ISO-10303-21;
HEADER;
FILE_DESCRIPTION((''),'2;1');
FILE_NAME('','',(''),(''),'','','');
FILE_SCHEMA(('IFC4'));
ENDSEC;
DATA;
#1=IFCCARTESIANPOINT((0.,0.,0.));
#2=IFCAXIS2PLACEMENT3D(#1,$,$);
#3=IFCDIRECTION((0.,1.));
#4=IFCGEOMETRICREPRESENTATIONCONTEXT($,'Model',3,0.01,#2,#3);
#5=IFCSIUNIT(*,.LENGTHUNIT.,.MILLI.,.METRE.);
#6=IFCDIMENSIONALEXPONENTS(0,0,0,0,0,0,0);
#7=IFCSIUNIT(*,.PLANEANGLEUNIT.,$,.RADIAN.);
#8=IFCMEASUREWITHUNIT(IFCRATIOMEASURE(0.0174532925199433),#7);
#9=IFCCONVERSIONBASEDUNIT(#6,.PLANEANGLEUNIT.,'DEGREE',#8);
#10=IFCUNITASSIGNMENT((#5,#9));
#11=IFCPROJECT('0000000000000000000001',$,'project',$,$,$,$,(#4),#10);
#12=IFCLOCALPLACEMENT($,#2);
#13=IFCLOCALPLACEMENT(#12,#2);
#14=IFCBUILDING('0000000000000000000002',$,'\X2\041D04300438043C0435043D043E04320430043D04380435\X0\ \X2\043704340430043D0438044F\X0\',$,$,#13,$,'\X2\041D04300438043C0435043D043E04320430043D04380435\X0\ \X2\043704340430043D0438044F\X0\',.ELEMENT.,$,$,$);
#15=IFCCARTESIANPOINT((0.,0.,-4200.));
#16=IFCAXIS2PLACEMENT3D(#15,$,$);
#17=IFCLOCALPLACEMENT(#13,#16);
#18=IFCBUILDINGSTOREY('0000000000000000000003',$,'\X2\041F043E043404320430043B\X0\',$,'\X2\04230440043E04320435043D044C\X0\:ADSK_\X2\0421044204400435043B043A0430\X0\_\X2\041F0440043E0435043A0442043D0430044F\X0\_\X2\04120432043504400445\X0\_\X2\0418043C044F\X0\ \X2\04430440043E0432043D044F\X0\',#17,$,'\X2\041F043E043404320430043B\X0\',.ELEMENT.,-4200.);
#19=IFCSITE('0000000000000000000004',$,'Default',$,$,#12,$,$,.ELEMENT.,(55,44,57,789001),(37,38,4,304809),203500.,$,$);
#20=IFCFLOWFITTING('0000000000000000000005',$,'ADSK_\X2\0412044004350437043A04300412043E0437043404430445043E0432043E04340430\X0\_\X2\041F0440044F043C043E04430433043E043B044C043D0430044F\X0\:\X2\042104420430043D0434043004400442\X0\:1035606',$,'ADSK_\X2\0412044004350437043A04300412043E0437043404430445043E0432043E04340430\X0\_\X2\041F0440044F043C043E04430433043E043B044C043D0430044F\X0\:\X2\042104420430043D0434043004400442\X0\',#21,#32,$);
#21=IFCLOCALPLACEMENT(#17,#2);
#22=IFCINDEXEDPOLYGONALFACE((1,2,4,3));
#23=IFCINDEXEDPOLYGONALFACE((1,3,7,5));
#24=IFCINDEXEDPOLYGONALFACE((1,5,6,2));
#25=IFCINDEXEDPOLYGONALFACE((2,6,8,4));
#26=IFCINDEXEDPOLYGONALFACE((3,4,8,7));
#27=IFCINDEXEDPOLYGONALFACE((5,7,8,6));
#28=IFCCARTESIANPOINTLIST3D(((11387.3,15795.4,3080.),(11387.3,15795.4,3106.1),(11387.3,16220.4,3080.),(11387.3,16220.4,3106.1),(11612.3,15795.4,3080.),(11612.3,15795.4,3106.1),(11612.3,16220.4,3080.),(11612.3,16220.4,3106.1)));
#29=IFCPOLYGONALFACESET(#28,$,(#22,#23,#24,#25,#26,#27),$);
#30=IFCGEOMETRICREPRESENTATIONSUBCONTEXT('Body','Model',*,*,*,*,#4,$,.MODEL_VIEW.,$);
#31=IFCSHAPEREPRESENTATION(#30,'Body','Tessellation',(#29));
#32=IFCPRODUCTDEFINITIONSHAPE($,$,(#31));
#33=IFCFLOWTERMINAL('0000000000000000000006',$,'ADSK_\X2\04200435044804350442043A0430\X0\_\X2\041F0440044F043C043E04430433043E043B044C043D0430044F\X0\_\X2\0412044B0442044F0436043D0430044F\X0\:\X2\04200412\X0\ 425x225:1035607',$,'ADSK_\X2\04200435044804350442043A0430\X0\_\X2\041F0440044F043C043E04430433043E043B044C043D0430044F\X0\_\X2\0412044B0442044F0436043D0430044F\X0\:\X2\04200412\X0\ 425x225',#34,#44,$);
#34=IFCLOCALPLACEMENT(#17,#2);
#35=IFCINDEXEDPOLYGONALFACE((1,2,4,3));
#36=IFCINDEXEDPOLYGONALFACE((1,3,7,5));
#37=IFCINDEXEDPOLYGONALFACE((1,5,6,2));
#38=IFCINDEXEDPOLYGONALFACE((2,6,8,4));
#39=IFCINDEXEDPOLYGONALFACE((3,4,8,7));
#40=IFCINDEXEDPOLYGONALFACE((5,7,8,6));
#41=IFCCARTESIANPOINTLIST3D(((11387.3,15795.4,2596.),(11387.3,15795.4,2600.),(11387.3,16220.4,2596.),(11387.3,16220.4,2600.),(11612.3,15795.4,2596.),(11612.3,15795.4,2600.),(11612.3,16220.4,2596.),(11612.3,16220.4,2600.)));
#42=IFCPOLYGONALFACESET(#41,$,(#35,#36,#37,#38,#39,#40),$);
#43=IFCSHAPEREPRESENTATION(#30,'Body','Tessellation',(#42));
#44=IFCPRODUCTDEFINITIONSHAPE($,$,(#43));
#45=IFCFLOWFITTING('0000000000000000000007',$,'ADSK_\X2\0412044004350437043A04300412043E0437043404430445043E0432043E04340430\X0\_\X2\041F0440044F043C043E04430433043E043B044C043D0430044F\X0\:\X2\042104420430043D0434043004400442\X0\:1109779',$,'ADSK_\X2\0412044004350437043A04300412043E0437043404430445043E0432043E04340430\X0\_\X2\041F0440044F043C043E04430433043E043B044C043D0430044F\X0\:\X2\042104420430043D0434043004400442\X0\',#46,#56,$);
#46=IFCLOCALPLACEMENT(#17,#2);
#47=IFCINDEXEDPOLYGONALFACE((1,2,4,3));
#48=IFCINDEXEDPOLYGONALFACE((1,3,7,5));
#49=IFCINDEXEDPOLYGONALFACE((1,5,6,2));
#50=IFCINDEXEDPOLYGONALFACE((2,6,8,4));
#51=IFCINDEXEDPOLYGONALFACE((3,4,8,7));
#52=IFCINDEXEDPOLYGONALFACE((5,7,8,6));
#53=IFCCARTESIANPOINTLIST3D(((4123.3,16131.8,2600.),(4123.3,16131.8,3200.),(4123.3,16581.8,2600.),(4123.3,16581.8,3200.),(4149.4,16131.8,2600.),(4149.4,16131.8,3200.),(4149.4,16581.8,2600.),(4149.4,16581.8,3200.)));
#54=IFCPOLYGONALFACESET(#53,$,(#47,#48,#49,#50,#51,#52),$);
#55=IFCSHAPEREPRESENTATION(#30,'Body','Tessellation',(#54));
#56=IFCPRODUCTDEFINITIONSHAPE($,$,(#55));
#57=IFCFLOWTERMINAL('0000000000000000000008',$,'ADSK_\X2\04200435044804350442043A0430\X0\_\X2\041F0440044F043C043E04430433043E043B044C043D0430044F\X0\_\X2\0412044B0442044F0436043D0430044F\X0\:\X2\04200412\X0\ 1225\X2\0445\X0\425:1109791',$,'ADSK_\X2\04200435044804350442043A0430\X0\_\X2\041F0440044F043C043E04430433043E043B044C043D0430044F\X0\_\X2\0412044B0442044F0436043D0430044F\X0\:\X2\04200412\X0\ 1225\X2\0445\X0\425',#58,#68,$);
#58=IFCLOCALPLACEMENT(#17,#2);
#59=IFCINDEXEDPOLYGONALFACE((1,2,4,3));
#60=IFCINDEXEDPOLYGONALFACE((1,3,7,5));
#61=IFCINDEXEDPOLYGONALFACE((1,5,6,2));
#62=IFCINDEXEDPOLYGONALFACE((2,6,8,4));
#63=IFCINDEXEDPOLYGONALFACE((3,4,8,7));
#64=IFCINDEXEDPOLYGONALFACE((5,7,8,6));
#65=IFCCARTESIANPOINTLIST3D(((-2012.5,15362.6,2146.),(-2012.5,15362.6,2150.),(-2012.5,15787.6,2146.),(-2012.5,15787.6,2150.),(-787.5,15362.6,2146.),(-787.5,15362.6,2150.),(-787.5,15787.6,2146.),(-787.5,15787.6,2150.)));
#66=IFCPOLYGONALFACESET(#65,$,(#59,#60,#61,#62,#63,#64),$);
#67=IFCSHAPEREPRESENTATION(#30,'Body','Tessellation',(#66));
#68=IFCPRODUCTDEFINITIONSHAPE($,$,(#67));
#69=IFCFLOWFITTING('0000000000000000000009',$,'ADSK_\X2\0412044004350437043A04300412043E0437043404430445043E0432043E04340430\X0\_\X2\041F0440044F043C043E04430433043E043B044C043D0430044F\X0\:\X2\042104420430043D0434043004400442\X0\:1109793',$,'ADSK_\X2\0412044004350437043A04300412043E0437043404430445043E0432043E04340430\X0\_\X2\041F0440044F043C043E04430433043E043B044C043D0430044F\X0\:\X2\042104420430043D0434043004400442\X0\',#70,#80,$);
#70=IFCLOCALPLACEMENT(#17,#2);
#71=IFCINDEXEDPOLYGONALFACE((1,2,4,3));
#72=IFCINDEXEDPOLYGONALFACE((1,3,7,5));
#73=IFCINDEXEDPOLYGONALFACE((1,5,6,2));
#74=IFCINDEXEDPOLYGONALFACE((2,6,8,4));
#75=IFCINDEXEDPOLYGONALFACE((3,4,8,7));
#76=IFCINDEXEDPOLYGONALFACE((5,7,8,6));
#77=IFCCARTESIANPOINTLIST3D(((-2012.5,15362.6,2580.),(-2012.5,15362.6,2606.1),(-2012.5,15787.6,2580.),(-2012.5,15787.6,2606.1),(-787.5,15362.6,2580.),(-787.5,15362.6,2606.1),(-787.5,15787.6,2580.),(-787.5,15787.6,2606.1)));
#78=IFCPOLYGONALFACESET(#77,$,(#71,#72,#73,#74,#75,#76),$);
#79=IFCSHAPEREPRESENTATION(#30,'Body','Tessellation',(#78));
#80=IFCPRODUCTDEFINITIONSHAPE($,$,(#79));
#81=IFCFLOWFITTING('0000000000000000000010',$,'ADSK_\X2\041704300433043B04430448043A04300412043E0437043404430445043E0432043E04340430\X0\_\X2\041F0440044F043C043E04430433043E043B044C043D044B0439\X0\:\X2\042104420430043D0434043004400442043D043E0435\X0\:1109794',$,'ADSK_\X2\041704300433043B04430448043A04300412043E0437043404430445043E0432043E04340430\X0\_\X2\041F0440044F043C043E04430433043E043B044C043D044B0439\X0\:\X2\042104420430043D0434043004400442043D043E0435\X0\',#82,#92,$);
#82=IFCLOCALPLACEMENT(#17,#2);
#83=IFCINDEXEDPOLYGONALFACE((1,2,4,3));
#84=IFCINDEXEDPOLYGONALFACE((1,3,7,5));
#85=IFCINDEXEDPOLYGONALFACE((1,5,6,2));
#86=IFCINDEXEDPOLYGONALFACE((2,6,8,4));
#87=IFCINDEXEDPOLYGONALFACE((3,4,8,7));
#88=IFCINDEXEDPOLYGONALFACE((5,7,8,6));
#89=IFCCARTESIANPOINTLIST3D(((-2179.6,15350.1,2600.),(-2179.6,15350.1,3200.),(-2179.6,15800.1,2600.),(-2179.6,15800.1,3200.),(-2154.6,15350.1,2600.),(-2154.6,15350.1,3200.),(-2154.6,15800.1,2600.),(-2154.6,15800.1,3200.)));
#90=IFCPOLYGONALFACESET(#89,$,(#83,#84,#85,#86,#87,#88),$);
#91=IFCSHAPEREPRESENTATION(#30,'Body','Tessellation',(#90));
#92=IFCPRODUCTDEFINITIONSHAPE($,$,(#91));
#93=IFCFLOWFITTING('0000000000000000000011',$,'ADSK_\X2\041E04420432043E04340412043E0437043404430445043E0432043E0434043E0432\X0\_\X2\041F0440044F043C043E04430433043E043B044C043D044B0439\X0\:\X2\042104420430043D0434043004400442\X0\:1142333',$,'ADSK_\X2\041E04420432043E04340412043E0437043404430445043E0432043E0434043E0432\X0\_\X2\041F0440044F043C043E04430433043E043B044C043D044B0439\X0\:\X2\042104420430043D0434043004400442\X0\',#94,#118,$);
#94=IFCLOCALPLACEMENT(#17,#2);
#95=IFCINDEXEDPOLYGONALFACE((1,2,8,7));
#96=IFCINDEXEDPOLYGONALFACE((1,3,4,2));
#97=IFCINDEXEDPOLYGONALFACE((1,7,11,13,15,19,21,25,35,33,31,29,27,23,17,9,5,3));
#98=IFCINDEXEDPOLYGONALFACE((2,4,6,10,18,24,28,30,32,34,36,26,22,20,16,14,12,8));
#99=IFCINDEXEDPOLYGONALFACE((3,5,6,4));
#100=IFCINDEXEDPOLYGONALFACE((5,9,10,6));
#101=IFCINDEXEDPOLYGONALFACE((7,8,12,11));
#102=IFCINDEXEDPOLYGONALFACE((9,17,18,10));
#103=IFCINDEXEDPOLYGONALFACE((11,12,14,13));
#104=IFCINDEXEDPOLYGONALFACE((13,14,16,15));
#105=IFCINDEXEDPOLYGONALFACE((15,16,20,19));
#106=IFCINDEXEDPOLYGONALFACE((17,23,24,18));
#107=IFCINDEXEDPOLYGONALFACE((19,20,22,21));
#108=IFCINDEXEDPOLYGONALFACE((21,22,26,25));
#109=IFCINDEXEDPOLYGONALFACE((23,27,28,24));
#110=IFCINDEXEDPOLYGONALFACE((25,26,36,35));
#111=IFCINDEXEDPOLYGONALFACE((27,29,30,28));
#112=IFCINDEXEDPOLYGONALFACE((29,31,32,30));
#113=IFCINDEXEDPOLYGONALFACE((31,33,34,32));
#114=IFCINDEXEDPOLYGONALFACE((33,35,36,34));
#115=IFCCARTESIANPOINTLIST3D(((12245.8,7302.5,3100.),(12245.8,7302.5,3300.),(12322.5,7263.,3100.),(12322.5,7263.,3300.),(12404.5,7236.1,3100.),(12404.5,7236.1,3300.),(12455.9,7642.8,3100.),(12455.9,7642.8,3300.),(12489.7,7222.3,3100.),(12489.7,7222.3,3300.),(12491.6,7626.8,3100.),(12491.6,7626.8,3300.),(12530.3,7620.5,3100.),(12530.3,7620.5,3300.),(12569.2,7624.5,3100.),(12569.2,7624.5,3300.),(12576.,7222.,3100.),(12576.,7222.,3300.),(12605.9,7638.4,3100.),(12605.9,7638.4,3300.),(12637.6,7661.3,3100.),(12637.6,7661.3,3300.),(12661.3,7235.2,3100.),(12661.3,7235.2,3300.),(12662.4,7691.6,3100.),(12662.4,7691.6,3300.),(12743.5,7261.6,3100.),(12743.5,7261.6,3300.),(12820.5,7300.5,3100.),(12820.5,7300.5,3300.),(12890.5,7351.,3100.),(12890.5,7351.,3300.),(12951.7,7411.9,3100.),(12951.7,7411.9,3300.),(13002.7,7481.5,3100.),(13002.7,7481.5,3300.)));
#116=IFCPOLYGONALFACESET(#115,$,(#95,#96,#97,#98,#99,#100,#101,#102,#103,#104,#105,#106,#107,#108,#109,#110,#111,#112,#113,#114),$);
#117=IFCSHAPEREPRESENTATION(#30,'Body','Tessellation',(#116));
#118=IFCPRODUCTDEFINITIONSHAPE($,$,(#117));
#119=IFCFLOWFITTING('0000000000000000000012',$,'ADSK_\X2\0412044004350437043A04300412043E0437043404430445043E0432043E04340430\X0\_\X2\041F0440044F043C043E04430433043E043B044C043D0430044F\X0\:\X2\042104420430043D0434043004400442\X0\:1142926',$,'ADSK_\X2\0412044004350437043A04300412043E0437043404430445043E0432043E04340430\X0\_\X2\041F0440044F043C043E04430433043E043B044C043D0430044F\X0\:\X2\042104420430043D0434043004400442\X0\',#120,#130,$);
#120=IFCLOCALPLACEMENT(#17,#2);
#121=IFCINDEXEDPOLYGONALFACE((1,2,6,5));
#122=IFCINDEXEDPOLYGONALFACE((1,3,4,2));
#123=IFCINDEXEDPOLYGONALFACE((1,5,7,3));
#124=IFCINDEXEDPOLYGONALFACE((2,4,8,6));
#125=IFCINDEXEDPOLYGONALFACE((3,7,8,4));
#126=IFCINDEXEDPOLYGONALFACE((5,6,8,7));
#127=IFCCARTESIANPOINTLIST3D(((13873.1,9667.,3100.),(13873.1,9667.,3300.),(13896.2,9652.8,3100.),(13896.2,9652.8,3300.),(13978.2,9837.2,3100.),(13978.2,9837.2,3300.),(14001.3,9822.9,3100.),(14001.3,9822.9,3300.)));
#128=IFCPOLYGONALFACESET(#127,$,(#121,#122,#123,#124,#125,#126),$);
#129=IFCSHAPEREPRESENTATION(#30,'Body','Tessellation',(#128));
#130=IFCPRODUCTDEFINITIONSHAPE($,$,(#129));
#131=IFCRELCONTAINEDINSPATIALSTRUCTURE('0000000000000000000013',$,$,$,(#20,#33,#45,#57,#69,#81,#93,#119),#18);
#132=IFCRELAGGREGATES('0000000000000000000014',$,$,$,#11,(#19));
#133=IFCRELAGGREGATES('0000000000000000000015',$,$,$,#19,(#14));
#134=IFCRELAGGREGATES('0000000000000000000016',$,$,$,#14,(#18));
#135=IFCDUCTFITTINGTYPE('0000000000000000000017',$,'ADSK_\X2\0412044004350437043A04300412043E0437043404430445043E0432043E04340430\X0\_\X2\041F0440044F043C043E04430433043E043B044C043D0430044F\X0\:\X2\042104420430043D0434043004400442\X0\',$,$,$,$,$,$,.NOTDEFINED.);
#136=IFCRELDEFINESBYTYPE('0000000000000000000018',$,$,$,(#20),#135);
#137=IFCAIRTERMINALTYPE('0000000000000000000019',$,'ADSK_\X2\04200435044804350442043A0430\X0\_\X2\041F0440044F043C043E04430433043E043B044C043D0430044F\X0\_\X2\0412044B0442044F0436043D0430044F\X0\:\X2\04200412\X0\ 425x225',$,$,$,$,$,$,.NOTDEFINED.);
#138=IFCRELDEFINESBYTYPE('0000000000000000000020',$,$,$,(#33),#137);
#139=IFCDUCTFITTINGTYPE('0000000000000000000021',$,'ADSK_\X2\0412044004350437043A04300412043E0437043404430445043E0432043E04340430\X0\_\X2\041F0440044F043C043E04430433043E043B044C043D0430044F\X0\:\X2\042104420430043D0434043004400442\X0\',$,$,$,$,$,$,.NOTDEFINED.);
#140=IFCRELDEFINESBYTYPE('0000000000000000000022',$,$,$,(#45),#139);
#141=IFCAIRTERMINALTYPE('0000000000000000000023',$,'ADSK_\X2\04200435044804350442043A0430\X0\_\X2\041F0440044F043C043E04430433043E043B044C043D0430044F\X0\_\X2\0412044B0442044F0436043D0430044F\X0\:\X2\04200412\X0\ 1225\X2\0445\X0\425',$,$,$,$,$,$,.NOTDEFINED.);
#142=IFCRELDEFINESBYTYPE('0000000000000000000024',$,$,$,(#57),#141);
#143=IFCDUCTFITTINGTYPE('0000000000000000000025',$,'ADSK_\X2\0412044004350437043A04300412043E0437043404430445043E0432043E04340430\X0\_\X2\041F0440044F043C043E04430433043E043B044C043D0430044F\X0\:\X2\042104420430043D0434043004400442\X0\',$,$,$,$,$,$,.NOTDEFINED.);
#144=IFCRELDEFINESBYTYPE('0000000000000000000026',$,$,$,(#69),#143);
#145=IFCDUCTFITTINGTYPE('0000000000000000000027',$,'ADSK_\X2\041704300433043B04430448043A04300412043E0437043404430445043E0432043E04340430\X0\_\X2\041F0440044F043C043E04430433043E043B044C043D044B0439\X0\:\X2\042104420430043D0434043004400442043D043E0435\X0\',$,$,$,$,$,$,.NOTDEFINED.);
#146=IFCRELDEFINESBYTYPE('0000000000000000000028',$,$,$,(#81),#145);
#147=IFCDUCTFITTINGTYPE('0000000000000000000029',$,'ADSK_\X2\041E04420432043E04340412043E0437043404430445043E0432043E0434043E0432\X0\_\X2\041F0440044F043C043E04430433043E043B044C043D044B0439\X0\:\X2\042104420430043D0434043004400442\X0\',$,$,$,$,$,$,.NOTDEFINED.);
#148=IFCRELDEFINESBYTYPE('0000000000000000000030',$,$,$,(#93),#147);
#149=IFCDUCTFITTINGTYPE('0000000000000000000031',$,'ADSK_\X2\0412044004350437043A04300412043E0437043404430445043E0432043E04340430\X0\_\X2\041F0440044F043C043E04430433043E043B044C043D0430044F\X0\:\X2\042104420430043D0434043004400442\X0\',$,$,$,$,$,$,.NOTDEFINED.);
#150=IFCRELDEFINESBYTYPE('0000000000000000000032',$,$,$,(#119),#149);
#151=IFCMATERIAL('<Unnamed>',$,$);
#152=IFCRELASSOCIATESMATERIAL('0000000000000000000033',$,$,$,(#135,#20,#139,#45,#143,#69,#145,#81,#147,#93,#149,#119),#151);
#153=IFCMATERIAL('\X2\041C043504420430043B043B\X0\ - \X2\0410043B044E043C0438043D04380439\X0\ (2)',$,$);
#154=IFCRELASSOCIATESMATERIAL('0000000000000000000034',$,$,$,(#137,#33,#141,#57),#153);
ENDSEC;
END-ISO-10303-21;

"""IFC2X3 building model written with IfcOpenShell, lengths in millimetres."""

from ifc_helpers import new_model, entity, si_unit, converted_unit, direction, frame, frame_2d, origin, origin_2d_with_axis, place, context, subcontext, project, spatial, polyline, circle_curve, parameter, trimmed, segment, composite_curve, rectangle, outline, extrude, source, transform, mapped, material, type_object, type_shapes, element, save


model = new_model("IFC2X3")

# Units and contexts
model_context = context("Model", 3, precision=0.01, world=origin(), true_north=direction((0.0, 1.0)))
body_context = subcontext(model_context, "Body", "Model", "MODEL_VIEW")
ifc_project = project(units=[si_unit("LENGTHUNIT", "METRE", prefix="MILLI"), converted_unit("PLANEANGLEUNIT", "DEGREE", entity("IfcRatioMeasure", 0.0174532925199433), si_unit("PLANEANGLEUNIT", "RADIAN"), dimensions=[0, 0, 0, 0, 0, 0, 0])], contexts=[model_context])

# Site, building, storey
site_placement = place(None, frame((0.0, 0.0, 0.0)))
site = spatial("IfcSite", under=ifc_project, at=site_placement, Name="Default", CompositionType="ELEMENT", RefLatitude=(55, 44, 57, 789001), RefLongitude=(37, 38, 4, 304809), RefElevation=203500.0)
building_placement = place(site_placement, origin())
building = spatial("IfcBuilding", under=site, at=building_placement, Name="Наименование здания", LongName="Наименование здания", CompositionType="ELEMENT")
storey_placement = place(building_placement, frame((0.0, 0.0, -4200.0)))
storey = spatial("IfcBuildingStorey", under=building, at=storey_placement, Name="Подвал", ObjectType="Уровень:ADSK_Стрелка_Проектная_Вверх_Имя уровня", LongName="Подвал", CompositionType="ELEMENT", Elevation=-4200.0)

# Flow fitting
ifc_material_1 = material(Name="<Unnamed>")
duct_fitting_type_1 = type_object("IfcDuctFittingType", Name="ADSK_ВрезкаВоздуховода_Прямоугольная:Стандарт", PredefinedType="NOTDEFINED", material=ifc_material_1)
shared_shape_1 = source(origin(), body_context, "Body", "SweptSolid", [
    extrude(rectangle(XDim=225.0, YDim=26.1, at=frame_2d((0.0, 0.0), x_axis=(1.0, 0.0))), frame((7.0, 0.0, -212.5), z_axis=(0.0, 0.0, 1.0), x_axis=(0.0, -1.0, 0.0)), (0.0, 0.0, 1.0), 425.0),
])
type_shapes(duct_fitting_type_1, [shared_shape_1])
flow_fitting_1_placement = place(storey_placement, frame((11499.8, 16007.9, 3100.0), z_axis=(0.0, -1.0, 0.0), x_axis=(0.0, 0.0, -1.0)))
element("IfcFlowFitting", 1, at=flow_fitting_1_placement, inside=storey, type_object=duct_fitting_type_1, material=ifc_material_1, Name="ADSK_ВрезкаВоздуховода_Прямоугольная:Стандарт:1035606", ObjectType="ADSK_ВрезкаВоздуховода_Прямоугольная:Стандарт", context=body_context, shape_type="MappedRepresentation", body=[
    mapped(shared_shape_1, transform((0.0, 0.0, 0.0), scale=1.0)),
])

# Flow terminal
ifc_material_2 = material(Name="Металл - Алюминий (2)")
air_terminal_type_1 = type_object("IfcAirTerminalType", Name="ADSK_Решетка_Прямоугольная_Вытяжная:РВ 425x225", PredefinedType="NOTDEFINED", material=ifc_material_2)
shared_shape_2 = source(origin(), body_context, "Body", "SweptSolid", [
    extrude(rectangle(XDim=4.0, YDim=425.0, at=origin_2d_with_axis()), frame((0.0, -2.0, -112.5), z_axis=(0.0, 0.0, 1.0), x_axis=(0.0, 1.0, 0.0)), (0.0, 0.0, 1.0), 225.0),
])
type_shapes(air_terminal_type_1, [shared_shape_2])
flow_terminal_1_placement = place(storey_placement, frame((11499.8, 16007.9, 2600.0), z_axis=(1.0, 0.0, 0.0), x_axis=(0.0, 1.0, 0.0)))
element("IfcFlowTerminal", 2, at=flow_terminal_1_placement, inside=storey, type_object=air_terminal_type_1, material=ifc_material_2, Name="ADSK_Решетка_Прямоугольная_Вытяжная:РВ 425x225:1035607", ObjectType="ADSK_Решетка_Прямоугольная_Вытяжная:РВ 425x225", context=body_context, shape_type="MappedRepresentation", body=[
    mapped(shared_shape_2, transform((0.0, 0.0, 0.0), scale=1.0)),
])

# Flow fitting
duct_fitting_type_2 = type_object("IfcDuctFittingType", Name="ADSK_ВрезкаВоздуховода_Прямоугольная:Стандарт", PredefinedType="NOTDEFINED", material=ifc_material_1)
shared_shape_3 = source(origin(), body_context, "Body", "SweptSolid", [
    extrude(rectangle(XDim=26.1, YDim=600.0, at=frame_2d((0.0, 0.0), x_axis=(1.0, 0.0))), frame((7.0, 0.0, -225.0)), (0.0, 0.0, 1.0), 450.0),
])
type_shapes(duct_fitting_type_2, [shared_shape_3])
flow_fitting_2_placement = place(storey_placement, frame((4143.3, 16356.8, 2900.0), z_axis=(0.0, 1.0, 0.0), x_axis=(-1.0, 0.0, 0.0)))
element("IfcFlowFitting", 3, at=flow_fitting_2_placement, inside=storey, type_object=duct_fitting_type_2, material=ifc_material_1, Name="ADSK_ВрезкаВоздуховода_Прямоугольная:Стандарт:1109779", ObjectType="ADSK_ВрезкаВоздуховода_Прямоугольная:Стандарт", context=body_context, shape_type="MappedRepresentation", body=[
    mapped(shared_shape_3, transform((0.0, 0.0, 0.0), scale=1.0)),
])

# Flow terminal
air_terminal_type_2 = type_object("IfcAirTerminalType", Name="ADSK_Решетка_Прямоугольная_Вытяжная:РВ 1225х425", PredefinedType="NOTDEFINED", material=ifc_material_2)
shared_shape_4 = source(origin(), body_context, "Body", "SweptSolid", [
    extrude(rectangle(XDim=4.0, YDim=1225.0, at=origin_2d_with_axis()), frame((0.0, -2.0, -212.5), z_axis=(0.0, 0.0, 1.0), x_axis=(0.0, 1.0, 0.0)), (0.0, 0.0, 1.0), 425.0),
])
type_shapes(air_terminal_type_2, [shared_shape_4])
flow_terminal_2_placement = place(storey_placement, frame((-1400.0, 15575.1, 2150.0), z_axis=(0.0, -1.0, 0.0), x_axis=(1.0, 0.0, 0.0)))
element("IfcFlowTerminal", 4, at=flow_terminal_2_placement, inside=storey, type_object=air_terminal_type_2, material=ifc_material_2, Name="ADSK_Решетка_Прямоугольная_Вытяжная:РВ 1225х425:1109791", ObjectType="ADSK_Решетка_Прямоугольная_Вытяжная:РВ 1225х425", context=body_context, shape_type="MappedRepresentation", body=[
    mapped(shared_shape_4, transform((0.0, 0.0, 0.0), scale=1.0)),
])

# Flow fittings
duct_fitting_type_3 = type_object("IfcDuctFittingType", Name="ADSK_ВрезкаВоздуховода_Прямоугольная:Стандарт", PredefinedType="NOTDEFINED", material=ifc_material_1)
shared_shape_5 = source(origin(), body_context, "Body", "SweptSolid", [
    extrude(rectangle(XDim=26.1, YDim=1225.0, at=frame_2d((0.0, 0.0), x_axis=(1.0, 0.0))), frame((7.0, 0.0, -212.5)), (0.0, 0.0, 1.0), 425.0),
])
type_shapes(duct_fitting_type_3, [shared_shape_5])
flow_fitting_3_placement = place(storey_placement, frame((-1400.0, 15575.1, 2600.0), z_axis=(0.0, -1.0, 0.0), x_axis=(0.0, 0.0, -1.0)))
element("IfcFlowFitting", 5, at=flow_fitting_3_placement, inside=storey, type_object=duct_fitting_type_3, material=ifc_material_1, Name="ADSK_ВрезкаВоздуховода_Прямоугольная:Стандарт:1109793", ObjectType="ADSK_ВрезкаВоздуховода_Прямоугольная:Стандарт", context=body_context, shape_type="MappedRepresentation", body=[
    mapped(shared_shape_5, transform((0.0, 0.0, 0.0), scale=1.0)),
])
duct_fitting_type_4 = type_object("IfcDuctFittingType", Name="ADSK_ЗаглушкаВоздуховода_Прямоугольный:Стандартное", PredefinedType="NOTDEFINED", material=ifc_material_1)
shared_shape_6 = source(origin(), body_context, "Body", "SweptSolid", [
    extrude(rectangle(XDim=25.0, YDim=450.0, at=frame_2d((0.0, 0.0), x_axis=(1.0, 0.0))), frame((12.5, 0.0, -300.0)), (0.0, 0.0, 1.0), 600.0),
])
type_shapes(duct_fitting_type_4, [shared_shape_6])
flow_fitting_4_placement = place(storey_placement, frame((-2154.6, 15575.1, 2900.0), z_axis=(0.0, 0.0, 1.0), x_axis=(-1.0, 0.0, 0.0)))
element("IfcFlowFitting", 6, at=flow_fitting_4_placement, inside=storey, type_object=duct_fitting_type_4, material=ifc_material_1, Name="ADSK_ЗаглушкаВоздуховода_Прямоугольный:Стандартное:1109794", ObjectType="ADSK_ЗаглушкаВоздуховода_Прямоугольный:Стандартное", context=body_context, shape_type="MappedRepresentation", body=[
    mapped(shared_shape_6, transform((0.0, 0.0, 0.0), scale=1.0)),
])
duct_fitting_type_5 = type_object("IfcDuctFittingType", Name="ADSK_ОтводВоздуховодов_Прямоугольный:Стандарт", PredefinedType="NOTDEFINED", material=ifc_material_1)
shared_shape_7 = source(origin(), body_context, "Body", "SweptSolid", [
    extrude(outline(composite_curve([segment(polyline([(-375.0, -175.0), (25.0, -175.0)]), True, "CONTINUOUS"), segment(trimmed(circle_curve(frame_2d((175.0, -175.0), x_axis=(0.0, 1.0)), 150.0), [parameter(0.0)], [parameter(90.0)], True, "PARAMETER"), False, "CONTINUOUS"), segment(polyline([(175.0, -25.0), (175.0, 375.0)]), True, "CONTINUOUS"), segment(trimmed(circle_curve(frame_2d((175.0, -175.0), x_axis=(0.0, 1.0)), 550.0), [parameter(0.0)], [parameter(90.0)], True, "PARAMETER"), True, "CONTINUOUS")], self_intersect=False)), frame((-175.0, 175.0, -100.0), z_axis=(0.0, 0.0, 1.0), x_axis=(-1.0, 0.0, 0.0)), (0.0, 0.0, 1.0), 200.0),
])
type_shapes(duct_fitting_type_5, [shared_shape_7])
flow_fitting_5_placement = place(storey_placement, frame((12648.7, 7288.8, 3200.0), z_axis=(0.0, 0.0, 1.0), x_axis=(0.850888, -0.525347, 0.0)))
element("IfcFlowFitting", 7, at=flow_fitting_5_placement, inside=storey, type_object=duct_fitting_type_5, material=ifc_material_1, Name="ADSK_ОтводВоздуховодов_Прямоугольный:Стандарт:1142333", ObjectType="ADSK_ОтводВоздуховодов_Прямоугольный:Стандарт", context=body_context, shape_type="MappedRepresentation", body=[
    mapped(shared_shape_7, transform((0.0, 0.0, 0.0), scale=1.0)),
])
duct_fitting_type_6 = type_object("IfcDuctFittingType", Name="ADSK_ВрезкаВоздуховода_Прямоугольная:Стандарт", PredefinedType="NOTDEFINED", material=ifc_material_1)
shared_shape_8 = source(origin(), body_context, "Body", "SweptSolid", [
    extrude(rectangle(XDim=200.0, YDim=27.1, at=frame_2d((0.0, 0.0), x_axis=(1.0, 0.0))), frame((7.0, 0.0, -100.0), z_axis=(0.0, 0.0, 1.0), x_axis=(0.0, -1.0, 0.0)), (0.0, 0.0, 1.0), 200.0),
])
type_shapes(duct_fitting_type_6, [shared_shape_8])
flow_fitting_6_placement = place(storey_placement, frame((13943.1, 9741.3, 3200.0), z_axis=(0.0, 0.0, -1.0), x_axis=(-0.850783, 0.525517, 0.0)))
element("IfcFlowFitting", 8, at=flow_fitting_6_placement, inside=storey, type_object=duct_fitting_type_6, material=ifc_material_1, Name="ADSK_ВрезкаВоздуховода_Прямоугольная:Стандарт:1142926", ObjectType="ADSK_ВрезкаВоздуховода_Прямоугольная:Стандарт", context=body_context, shape_type="MappedRepresentation", body=[
    mapped(shared_shape_8, transform((0.0, 0.0, 0.0), scale=1.0)),
])

save(model, "model.ifc")
